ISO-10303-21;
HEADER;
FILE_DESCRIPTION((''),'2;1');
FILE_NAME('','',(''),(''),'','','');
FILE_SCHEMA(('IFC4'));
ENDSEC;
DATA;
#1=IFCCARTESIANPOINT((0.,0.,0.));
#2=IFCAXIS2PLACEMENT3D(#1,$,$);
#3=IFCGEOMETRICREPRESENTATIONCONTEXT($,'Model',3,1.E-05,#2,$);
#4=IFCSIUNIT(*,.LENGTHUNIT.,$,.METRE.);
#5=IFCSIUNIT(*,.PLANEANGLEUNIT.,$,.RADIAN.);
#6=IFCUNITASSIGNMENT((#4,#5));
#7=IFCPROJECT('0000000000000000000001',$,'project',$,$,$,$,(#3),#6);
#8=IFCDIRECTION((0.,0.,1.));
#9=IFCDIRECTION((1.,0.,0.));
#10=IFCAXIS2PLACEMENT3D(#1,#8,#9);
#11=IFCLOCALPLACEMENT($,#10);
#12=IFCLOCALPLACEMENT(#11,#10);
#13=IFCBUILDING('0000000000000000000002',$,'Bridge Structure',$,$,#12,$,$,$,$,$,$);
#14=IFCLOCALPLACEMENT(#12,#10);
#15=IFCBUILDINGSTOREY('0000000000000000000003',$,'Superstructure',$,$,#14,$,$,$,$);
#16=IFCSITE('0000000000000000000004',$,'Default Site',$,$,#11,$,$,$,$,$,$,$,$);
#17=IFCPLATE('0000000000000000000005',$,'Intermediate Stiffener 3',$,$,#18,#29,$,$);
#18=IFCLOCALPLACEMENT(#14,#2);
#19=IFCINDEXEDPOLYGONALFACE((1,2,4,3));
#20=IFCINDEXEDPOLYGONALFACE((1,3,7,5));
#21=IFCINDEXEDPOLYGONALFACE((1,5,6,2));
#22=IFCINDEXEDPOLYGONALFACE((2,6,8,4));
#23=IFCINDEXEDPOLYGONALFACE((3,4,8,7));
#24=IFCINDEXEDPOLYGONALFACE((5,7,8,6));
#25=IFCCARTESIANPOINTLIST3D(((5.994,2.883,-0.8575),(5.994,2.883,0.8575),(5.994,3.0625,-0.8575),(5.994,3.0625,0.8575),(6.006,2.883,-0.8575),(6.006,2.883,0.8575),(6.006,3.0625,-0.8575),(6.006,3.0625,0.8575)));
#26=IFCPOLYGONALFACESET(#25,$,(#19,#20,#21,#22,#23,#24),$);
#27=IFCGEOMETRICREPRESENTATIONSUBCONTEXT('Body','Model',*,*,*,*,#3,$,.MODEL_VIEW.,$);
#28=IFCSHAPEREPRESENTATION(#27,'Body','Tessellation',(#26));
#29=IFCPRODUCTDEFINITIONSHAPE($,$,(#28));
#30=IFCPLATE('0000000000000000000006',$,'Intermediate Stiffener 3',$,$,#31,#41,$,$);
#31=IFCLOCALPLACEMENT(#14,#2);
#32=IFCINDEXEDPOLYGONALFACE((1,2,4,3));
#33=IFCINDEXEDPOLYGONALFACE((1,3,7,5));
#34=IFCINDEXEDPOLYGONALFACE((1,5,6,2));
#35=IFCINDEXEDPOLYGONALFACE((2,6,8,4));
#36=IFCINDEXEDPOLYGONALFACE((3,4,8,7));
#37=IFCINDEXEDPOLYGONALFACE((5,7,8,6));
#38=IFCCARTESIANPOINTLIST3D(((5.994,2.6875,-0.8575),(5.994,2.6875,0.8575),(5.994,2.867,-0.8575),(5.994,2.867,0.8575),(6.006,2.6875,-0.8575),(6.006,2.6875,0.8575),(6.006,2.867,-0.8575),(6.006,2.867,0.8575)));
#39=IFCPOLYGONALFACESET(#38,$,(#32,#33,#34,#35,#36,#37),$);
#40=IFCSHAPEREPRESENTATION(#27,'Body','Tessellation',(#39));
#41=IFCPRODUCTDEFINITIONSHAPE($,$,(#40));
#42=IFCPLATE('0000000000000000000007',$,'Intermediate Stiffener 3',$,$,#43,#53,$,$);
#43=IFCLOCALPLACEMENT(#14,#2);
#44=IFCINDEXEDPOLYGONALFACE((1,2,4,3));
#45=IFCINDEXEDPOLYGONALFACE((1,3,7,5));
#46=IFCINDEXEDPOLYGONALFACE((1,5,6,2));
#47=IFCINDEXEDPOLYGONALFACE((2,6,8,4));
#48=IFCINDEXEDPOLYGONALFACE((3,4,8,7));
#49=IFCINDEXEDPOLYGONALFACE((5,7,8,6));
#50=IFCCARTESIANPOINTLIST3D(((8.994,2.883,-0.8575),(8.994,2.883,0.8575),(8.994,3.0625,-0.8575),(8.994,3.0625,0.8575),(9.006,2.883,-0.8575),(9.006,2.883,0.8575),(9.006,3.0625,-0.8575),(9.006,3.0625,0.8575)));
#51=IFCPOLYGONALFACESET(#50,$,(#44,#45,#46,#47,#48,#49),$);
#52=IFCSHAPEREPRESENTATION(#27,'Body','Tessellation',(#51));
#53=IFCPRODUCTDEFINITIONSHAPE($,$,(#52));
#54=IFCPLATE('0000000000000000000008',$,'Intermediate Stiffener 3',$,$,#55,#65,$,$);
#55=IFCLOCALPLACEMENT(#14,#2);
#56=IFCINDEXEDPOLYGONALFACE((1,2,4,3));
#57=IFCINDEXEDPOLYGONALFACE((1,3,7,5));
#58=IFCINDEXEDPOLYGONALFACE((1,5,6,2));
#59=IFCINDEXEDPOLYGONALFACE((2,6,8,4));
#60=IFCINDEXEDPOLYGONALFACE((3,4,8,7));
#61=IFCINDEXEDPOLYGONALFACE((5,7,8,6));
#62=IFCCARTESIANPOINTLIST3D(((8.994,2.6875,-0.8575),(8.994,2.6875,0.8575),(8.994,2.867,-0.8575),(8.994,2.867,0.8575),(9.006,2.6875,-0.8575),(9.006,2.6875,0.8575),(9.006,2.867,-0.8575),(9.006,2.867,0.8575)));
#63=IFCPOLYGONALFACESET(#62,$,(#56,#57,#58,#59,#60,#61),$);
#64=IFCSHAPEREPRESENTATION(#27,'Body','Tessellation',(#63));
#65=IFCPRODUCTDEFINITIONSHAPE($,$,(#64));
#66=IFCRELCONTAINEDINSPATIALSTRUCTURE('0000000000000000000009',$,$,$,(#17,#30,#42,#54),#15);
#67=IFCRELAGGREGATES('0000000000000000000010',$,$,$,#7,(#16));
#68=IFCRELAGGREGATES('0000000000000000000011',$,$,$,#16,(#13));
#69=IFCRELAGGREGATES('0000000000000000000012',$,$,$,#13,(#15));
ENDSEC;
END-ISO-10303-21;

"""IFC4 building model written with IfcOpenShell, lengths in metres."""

from ifc_helpers import new_model, si_unit, frame, origin, origin_with_axes, origin_2d_with_axis, place, context, subcontext, project, spatial, rectangle, extrude, element, save


model = new_model("IFC4")

# Units and contexts
model_context = context("Model", 3, precision=1e-05, world=origin())
body_context = subcontext(model_context, "Body", "Model", "MODEL_VIEW")
ifc_project = project(units=[si_unit("LENGTHUNIT", "METRE"), si_unit("PLANEANGLEUNIT", "RADIAN")], contexts=[model_context])

# Site, building, storey
site_placement = place(None, origin_with_axes())
site = spatial("IfcSite", under=ifc_project, at=site_placement, Name="Default Site")
building_placement = place(site_placement, origin_with_axes())
building = spatial("IfcBuilding", under=site, at=building_placement, Name="Bridge Structure")
storey_placement = place(building_placement, origin_with_axes())
storey = spatial("IfcBuildingStorey", under=building, at=storey_placement, Name="Superstructure")

# Plates
for number, where, z_axis, x_axis, name in (
    (1, (6.0, 2.9728, -0.8575), (0.0, 0.0, 1.0), (1.0, 0.0, 0.0), "Intermediate Stiffener 3"),
    (2, (6.0, 2.7772, -0.8575), (0.0, 0.0, 1.0), (1.0, 0.0, 0.0), "Intermediate Stiffener 3"),
    (3, (9.0, 2.9728, -0.8575), (0.0, 0.0, 1.0), (1.0, 0.0, 0.0), "Intermediate Stiffener 3"),
    (4, (9.0, 2.7772, -0.8575), (0.0, 0.0, 1.0), (1.0, 0.0, 0.0), "Intermediate Stiffener 3"),
):
    element("IfcPlate", number, at=place(storey_placement, frame(where, z_axis=z_axis, x_axis=x_axis)), inside=storey, Name=name, context=body_context, shape_type="SweptSolid", body=[
        extrude(rectangle(XDim=0.012, YDim=0.1795, at=origin_2d_with_axis()), origin_with_axes(), (0.0, 0.0, 1.0), 1.715),
    ])

save(model, "model.ifc")
